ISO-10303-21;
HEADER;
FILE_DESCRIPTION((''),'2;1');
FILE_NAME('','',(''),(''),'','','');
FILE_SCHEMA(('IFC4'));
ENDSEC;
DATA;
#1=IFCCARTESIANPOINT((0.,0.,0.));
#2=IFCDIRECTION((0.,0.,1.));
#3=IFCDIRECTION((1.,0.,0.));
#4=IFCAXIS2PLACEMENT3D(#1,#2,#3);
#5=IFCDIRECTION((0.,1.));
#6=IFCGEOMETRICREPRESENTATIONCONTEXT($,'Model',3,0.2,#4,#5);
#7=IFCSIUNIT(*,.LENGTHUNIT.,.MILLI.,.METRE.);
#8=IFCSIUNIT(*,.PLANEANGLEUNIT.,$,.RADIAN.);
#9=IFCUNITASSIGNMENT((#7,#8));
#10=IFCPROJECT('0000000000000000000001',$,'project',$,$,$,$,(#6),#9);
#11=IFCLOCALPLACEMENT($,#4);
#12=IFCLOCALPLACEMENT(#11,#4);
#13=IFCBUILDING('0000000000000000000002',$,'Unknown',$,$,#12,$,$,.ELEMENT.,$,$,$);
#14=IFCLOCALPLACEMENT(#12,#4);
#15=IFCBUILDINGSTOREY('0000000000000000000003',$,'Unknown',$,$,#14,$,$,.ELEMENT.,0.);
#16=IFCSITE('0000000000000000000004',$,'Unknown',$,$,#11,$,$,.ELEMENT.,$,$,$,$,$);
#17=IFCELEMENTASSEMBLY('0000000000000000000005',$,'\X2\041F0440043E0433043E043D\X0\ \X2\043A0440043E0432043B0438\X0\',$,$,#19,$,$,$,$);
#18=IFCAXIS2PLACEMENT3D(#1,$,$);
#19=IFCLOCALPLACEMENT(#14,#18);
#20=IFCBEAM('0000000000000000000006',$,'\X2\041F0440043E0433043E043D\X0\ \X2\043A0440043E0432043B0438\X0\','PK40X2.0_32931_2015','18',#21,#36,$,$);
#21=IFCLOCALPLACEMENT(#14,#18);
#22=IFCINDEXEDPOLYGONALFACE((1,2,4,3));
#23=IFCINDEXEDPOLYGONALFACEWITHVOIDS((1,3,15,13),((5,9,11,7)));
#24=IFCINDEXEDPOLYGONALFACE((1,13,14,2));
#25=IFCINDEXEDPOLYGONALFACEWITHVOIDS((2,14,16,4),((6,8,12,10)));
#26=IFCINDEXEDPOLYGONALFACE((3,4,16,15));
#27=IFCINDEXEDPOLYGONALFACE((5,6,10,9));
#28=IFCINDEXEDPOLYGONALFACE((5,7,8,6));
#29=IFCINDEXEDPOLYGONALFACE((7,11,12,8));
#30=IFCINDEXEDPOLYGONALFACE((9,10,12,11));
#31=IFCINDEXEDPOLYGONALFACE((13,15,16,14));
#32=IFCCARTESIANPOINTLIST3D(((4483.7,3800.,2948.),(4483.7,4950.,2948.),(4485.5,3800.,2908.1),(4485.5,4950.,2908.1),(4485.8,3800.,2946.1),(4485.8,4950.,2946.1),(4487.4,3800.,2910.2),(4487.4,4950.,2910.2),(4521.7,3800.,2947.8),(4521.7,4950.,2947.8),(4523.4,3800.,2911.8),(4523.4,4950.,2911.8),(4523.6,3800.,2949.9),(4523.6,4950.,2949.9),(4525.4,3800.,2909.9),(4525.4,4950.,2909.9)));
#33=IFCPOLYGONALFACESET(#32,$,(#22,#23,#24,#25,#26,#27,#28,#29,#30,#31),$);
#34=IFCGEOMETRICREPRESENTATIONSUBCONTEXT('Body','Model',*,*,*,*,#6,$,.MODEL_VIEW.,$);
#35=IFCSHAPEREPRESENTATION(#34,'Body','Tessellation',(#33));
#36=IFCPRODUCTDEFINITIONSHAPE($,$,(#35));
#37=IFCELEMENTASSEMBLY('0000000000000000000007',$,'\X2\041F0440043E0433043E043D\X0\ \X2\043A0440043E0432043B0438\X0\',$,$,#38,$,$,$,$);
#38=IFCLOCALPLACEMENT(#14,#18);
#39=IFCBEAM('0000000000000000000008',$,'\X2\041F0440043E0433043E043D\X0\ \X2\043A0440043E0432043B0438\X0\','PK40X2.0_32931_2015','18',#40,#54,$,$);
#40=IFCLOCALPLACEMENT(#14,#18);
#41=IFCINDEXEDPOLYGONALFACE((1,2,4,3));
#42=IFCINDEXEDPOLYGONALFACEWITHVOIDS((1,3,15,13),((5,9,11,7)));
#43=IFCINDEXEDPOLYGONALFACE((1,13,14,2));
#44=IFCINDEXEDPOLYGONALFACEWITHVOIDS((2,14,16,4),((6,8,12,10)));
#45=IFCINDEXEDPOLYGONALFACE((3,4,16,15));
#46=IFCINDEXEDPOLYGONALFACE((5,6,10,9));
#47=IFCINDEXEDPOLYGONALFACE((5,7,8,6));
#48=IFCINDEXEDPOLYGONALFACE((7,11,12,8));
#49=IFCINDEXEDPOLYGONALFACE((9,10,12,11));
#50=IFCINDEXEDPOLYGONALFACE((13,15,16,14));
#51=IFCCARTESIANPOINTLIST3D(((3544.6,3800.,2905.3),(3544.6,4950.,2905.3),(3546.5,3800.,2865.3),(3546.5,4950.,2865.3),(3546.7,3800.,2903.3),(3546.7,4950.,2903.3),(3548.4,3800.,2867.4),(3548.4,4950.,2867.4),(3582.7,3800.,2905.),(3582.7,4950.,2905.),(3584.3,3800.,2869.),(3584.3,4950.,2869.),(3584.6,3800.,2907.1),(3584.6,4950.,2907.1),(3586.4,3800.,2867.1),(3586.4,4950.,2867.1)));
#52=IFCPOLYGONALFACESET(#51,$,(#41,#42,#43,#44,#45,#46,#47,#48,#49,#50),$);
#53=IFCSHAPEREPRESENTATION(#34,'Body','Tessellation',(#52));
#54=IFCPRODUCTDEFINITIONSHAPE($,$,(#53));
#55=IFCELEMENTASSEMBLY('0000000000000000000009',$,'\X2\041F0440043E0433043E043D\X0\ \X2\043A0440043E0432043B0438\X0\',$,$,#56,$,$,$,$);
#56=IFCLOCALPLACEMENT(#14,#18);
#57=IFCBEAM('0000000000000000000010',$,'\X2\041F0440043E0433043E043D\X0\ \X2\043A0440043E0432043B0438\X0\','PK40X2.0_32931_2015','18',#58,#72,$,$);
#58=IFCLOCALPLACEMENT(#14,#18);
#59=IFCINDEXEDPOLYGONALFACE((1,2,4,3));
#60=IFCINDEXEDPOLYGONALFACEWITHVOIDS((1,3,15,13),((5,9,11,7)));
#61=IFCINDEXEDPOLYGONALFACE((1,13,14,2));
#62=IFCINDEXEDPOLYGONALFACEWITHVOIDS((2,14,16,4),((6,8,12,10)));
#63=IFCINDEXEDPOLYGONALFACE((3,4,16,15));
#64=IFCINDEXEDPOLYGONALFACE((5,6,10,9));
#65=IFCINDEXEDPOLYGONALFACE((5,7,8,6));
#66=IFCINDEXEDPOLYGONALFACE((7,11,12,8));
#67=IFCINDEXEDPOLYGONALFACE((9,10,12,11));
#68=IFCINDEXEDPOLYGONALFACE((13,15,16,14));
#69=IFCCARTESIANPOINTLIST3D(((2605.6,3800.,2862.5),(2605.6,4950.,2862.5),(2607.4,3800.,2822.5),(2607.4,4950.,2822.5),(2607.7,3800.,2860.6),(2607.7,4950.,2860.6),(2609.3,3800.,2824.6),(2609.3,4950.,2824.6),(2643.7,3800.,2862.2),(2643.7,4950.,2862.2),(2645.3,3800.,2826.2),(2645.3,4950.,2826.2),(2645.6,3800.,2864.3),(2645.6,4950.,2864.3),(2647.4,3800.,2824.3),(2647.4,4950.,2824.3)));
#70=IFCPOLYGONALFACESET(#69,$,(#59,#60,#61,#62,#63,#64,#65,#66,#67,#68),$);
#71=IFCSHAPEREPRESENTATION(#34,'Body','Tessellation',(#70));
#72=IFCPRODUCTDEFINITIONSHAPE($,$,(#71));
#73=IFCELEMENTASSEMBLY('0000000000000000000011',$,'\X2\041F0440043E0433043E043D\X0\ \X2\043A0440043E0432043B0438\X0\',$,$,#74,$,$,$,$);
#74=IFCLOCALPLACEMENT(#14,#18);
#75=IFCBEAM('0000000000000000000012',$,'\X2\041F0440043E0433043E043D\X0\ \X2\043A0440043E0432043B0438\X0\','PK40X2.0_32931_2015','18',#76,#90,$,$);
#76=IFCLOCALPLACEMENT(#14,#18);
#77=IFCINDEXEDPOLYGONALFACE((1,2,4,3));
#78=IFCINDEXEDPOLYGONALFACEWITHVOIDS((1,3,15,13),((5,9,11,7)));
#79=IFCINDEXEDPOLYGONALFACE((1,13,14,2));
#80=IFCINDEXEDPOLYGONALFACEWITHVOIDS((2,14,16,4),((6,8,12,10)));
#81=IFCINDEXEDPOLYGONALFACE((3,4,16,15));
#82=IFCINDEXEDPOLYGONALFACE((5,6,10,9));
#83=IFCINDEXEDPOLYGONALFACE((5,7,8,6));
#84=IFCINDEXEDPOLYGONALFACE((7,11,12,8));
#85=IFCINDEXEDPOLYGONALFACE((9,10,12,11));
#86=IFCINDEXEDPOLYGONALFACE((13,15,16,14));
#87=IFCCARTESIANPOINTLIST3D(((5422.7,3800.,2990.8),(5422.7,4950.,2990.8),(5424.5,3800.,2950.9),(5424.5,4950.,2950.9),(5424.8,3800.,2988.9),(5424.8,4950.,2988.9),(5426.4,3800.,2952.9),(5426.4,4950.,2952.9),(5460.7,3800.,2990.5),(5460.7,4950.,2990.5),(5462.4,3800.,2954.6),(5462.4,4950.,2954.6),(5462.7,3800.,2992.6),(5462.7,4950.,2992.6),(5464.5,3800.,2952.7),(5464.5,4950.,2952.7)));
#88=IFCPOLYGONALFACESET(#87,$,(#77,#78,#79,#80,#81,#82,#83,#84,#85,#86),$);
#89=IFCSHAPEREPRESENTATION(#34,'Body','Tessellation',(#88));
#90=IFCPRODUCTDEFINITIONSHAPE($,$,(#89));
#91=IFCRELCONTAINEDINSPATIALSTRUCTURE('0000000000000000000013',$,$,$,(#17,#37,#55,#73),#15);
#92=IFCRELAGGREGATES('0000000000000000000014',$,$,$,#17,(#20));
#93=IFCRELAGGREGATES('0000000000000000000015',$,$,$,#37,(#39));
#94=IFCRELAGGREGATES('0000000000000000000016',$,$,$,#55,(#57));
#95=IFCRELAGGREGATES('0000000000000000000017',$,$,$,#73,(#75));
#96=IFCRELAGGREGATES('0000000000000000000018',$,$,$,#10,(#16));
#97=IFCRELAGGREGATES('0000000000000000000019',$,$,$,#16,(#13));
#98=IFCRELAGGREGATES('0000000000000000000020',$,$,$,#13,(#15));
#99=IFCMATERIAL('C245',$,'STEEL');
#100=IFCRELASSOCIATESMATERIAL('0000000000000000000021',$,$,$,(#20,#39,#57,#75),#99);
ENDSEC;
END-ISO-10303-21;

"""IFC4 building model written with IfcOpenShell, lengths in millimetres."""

from ifc_helpers import new_model, si_unit, direction, frame, origin_with_axes, place, context, subcontext, project, spatial, line, indexed_curve, outline, extrude, material, element, aggregate, save


model = new_model("IFC4")

# Units and contexts
model_context = context("Model", 3, precision=0.2, world=origin_with_axes(), true_north=direction((0.0, 1.0)))
body_context = subcontext(model_context, "Body", "Model", "MODEL_VIEW")
ifc_project = project(units=[si_unit("LENGTHUNIT", "METRE", prefix="MILLI"), si_unit("PLANEANGLEUNIT", "RADIAN")], contexts=[model_context])

# Site, building, storey
site_placement = place(None, origin_with_axes())
site = spatial("IfcSite", under=ifc_project, at=site_placement, Name="Unknown", CompositionType="ELEMENT")
building_placement = place(site_placement, origin_with_axes())
building = spatial("IfcBuilding", under=site, at=building_placement, Name="Unknown", CompositionType="ELEMENT")
storey_placement = place(building_placement, origin_with_axes())
storey = spatial("IfcBuildingStorey", under=building, at=storey_placement, Name="Unknown", CompositionType="ELEMENT", Elevation=0.0)

# Shared definitions
ifc_material_1 = material(Name="C245", Category="STEEL")

# Element assemblies, beams
assembly_1_placement = place(storey_placement, frame((4504.6, 4950.0, 2929.0), z_axis=(-0.998964, 0.0, -0.045508), x_axis=(0.0, -1.0, 0.0)))
assembly_1 = element("IfcElementAssembly", 1, at=assembly_1_placement, inside=storey, Name="Прогон кровли")
beam_1_placement = place(assembly_1_placement, origin_with_axes())
beam_1 = element("IfcBeam", 2, at=beam_1_placement, material=ifc_material_1, Name="Прогон кровли", Description="PK40X2.0_32931_2015", ObjectType="18", context=body_context, shape_type="SolidModel", body=[
    extrude(outline(indexed_curve([(-20.0, -20.0), (20.0, -20.0), (20.0, 20.0), (-20.0, 20.0)], segments=[line(1, 2, 3, 4, 1)]), holes=[indexed_curve([(-18.0, -18.0), (-18.0, 18.0), (18.0, 18.0), (18.0, -18.0)], segments=[line(1, 2, 3, 4, 1)])]), frame((0.0, 0.0, 0.0), z_axis=(-1.0, 0.0, 0.0), x_axis=(0.0, 0.0, 1.0)), (0.0, 0.0, -1.0), 1150.0),
])
aggregate(assembly_1, [beam_1])
assembly_2_placement = place(storey_placement, frame((3565.5, 4950.0, 2886.2), z_axis=(-0.998964, 0.0, -0.045508), x_axis=(0.0, -1.0, 0.0)))
assembly_2 = element("IfcElementAssembly", 3, at=assembly_2_placement, inside=storey, Name="Прогон кровли")
beam_2_placement = place(assembly_2_placement, origin_with_axes())
beam_2 = element("IfcBeam", 4, at=beam_2_placement, material=ifc_material_1, Name="Прогон кровли", Description="PK40X2.0_32931_2015", ObjectType="18", context=body_context, shape_type="SolidModel", body=[
    extrude(outline(indexed_curve([(-20.0, -20.0), (20.0, -20.0), (20.0, 20.0), (-20.0, 20.0)], segments=[line(1, 2, 3, 4, 1)]), holes=[indexed_curve([(-18.0, -18.0), (-18.0, 18.0), (18.0, 18.0), (18.0, -18.0)], segments=[line(1, 2, 3, 4, 1)])]), frame((0.0, 0.0, 0.0), z_axis=(-1.0, 0.0, 0.0), x_axis=(0.0, 0.0, 1.0)), (0.0, 0.0, -1.0), 1150.0),
])
aggregate(assembly_2, [beam_2])
assembly_3_placement = place(storey_placement, frame((2626.5, 4950.0, 2843.4), z_axis=(-0.998964, 0.0, -0.045508), x_axis=(0.0, -1.0, 0.0)))
assembly_3 = element("IfcElementAssembly", 5, at=assembly_3_placement, inside=storey, Name="Прогон кровли")
beam_3_placement = place(assembly_3_placement, origin_with_axes())
beam_3 = element("IfcBeam", 6, at=beam_3_placement, material=ifc_material_1, Name="Прогон кровли", Description="PK40X2.0_32931_2015", ObjectType="18", context=body_context, shape_type="SolidModel", body=[
    extrude(outline(indexed_curve([(-20.0, -20.0), (20.0, -20.0), (20.0, 20.0), (-20.0, 20.0)], segments=[line(1, 2, 3, 4, 1)]), holes=[indexed_curve([(-18.0, -18.0), (-18.0, 18.0), (18.0, 18.0), (18.0, -18.0)], segments=[line(1, 2, 3, 4, 1)])]), frame((0.0, 0.0, 0.0), z_axis=(-1.0, 0.0, 0.0), x_axis=(0.0, 0.0, 1.0)), (0.0, 0.0, -1.0), 1150.0),
])
aggregate(assembly_3, [beam_3])
assembly_4_placement = place(storey_placement, frame((5443.6, 4950.0, 2971.7), z_axis=(-0.998964, 0.0, -0.045508), x_axis=(0.0, -1.0, 0.0)))
assembly_4 = element("IfcElementAssembly", 7, at=assembly_4_placement, inside=storey, Name="Прогон кровли")
beam_4_placement = place(assembly_4_placement, origin_with_axes())
beam_4 = element("IfcBeam", 8, at=beam_4_placement, material=ifc_material_1, Name="Прогон кровли", Description="PK40X2.0_32931_2015", ObjectType="18", context=body_context, shape_type="SolidModel", body=[
    extrude(outline(indexed_curve([(-20.0, -20.0), (20.0, -20.0), (20.0, 20.0), (-20.0, 20.0)], segments=[line(1, 2, 3, 4, 1)]), holes=[indexed_curve([(-18.0, -18.0), (-18.0, 18.0), (18.0, 18.0), (18.0, -18.0)], segments=[line(1, 2, 3, 4, 1)])]), frame((0.0, 0.0, 0.0), z_axis=(-1.0, 0.0, 0.0), x_axis=(0.0, 0.0, 1.0)), (0.0, 0.0, -1.0), 1150.0),
])
aggregate(assembly_4, [beam_4])

save(model, "model.ifc")
